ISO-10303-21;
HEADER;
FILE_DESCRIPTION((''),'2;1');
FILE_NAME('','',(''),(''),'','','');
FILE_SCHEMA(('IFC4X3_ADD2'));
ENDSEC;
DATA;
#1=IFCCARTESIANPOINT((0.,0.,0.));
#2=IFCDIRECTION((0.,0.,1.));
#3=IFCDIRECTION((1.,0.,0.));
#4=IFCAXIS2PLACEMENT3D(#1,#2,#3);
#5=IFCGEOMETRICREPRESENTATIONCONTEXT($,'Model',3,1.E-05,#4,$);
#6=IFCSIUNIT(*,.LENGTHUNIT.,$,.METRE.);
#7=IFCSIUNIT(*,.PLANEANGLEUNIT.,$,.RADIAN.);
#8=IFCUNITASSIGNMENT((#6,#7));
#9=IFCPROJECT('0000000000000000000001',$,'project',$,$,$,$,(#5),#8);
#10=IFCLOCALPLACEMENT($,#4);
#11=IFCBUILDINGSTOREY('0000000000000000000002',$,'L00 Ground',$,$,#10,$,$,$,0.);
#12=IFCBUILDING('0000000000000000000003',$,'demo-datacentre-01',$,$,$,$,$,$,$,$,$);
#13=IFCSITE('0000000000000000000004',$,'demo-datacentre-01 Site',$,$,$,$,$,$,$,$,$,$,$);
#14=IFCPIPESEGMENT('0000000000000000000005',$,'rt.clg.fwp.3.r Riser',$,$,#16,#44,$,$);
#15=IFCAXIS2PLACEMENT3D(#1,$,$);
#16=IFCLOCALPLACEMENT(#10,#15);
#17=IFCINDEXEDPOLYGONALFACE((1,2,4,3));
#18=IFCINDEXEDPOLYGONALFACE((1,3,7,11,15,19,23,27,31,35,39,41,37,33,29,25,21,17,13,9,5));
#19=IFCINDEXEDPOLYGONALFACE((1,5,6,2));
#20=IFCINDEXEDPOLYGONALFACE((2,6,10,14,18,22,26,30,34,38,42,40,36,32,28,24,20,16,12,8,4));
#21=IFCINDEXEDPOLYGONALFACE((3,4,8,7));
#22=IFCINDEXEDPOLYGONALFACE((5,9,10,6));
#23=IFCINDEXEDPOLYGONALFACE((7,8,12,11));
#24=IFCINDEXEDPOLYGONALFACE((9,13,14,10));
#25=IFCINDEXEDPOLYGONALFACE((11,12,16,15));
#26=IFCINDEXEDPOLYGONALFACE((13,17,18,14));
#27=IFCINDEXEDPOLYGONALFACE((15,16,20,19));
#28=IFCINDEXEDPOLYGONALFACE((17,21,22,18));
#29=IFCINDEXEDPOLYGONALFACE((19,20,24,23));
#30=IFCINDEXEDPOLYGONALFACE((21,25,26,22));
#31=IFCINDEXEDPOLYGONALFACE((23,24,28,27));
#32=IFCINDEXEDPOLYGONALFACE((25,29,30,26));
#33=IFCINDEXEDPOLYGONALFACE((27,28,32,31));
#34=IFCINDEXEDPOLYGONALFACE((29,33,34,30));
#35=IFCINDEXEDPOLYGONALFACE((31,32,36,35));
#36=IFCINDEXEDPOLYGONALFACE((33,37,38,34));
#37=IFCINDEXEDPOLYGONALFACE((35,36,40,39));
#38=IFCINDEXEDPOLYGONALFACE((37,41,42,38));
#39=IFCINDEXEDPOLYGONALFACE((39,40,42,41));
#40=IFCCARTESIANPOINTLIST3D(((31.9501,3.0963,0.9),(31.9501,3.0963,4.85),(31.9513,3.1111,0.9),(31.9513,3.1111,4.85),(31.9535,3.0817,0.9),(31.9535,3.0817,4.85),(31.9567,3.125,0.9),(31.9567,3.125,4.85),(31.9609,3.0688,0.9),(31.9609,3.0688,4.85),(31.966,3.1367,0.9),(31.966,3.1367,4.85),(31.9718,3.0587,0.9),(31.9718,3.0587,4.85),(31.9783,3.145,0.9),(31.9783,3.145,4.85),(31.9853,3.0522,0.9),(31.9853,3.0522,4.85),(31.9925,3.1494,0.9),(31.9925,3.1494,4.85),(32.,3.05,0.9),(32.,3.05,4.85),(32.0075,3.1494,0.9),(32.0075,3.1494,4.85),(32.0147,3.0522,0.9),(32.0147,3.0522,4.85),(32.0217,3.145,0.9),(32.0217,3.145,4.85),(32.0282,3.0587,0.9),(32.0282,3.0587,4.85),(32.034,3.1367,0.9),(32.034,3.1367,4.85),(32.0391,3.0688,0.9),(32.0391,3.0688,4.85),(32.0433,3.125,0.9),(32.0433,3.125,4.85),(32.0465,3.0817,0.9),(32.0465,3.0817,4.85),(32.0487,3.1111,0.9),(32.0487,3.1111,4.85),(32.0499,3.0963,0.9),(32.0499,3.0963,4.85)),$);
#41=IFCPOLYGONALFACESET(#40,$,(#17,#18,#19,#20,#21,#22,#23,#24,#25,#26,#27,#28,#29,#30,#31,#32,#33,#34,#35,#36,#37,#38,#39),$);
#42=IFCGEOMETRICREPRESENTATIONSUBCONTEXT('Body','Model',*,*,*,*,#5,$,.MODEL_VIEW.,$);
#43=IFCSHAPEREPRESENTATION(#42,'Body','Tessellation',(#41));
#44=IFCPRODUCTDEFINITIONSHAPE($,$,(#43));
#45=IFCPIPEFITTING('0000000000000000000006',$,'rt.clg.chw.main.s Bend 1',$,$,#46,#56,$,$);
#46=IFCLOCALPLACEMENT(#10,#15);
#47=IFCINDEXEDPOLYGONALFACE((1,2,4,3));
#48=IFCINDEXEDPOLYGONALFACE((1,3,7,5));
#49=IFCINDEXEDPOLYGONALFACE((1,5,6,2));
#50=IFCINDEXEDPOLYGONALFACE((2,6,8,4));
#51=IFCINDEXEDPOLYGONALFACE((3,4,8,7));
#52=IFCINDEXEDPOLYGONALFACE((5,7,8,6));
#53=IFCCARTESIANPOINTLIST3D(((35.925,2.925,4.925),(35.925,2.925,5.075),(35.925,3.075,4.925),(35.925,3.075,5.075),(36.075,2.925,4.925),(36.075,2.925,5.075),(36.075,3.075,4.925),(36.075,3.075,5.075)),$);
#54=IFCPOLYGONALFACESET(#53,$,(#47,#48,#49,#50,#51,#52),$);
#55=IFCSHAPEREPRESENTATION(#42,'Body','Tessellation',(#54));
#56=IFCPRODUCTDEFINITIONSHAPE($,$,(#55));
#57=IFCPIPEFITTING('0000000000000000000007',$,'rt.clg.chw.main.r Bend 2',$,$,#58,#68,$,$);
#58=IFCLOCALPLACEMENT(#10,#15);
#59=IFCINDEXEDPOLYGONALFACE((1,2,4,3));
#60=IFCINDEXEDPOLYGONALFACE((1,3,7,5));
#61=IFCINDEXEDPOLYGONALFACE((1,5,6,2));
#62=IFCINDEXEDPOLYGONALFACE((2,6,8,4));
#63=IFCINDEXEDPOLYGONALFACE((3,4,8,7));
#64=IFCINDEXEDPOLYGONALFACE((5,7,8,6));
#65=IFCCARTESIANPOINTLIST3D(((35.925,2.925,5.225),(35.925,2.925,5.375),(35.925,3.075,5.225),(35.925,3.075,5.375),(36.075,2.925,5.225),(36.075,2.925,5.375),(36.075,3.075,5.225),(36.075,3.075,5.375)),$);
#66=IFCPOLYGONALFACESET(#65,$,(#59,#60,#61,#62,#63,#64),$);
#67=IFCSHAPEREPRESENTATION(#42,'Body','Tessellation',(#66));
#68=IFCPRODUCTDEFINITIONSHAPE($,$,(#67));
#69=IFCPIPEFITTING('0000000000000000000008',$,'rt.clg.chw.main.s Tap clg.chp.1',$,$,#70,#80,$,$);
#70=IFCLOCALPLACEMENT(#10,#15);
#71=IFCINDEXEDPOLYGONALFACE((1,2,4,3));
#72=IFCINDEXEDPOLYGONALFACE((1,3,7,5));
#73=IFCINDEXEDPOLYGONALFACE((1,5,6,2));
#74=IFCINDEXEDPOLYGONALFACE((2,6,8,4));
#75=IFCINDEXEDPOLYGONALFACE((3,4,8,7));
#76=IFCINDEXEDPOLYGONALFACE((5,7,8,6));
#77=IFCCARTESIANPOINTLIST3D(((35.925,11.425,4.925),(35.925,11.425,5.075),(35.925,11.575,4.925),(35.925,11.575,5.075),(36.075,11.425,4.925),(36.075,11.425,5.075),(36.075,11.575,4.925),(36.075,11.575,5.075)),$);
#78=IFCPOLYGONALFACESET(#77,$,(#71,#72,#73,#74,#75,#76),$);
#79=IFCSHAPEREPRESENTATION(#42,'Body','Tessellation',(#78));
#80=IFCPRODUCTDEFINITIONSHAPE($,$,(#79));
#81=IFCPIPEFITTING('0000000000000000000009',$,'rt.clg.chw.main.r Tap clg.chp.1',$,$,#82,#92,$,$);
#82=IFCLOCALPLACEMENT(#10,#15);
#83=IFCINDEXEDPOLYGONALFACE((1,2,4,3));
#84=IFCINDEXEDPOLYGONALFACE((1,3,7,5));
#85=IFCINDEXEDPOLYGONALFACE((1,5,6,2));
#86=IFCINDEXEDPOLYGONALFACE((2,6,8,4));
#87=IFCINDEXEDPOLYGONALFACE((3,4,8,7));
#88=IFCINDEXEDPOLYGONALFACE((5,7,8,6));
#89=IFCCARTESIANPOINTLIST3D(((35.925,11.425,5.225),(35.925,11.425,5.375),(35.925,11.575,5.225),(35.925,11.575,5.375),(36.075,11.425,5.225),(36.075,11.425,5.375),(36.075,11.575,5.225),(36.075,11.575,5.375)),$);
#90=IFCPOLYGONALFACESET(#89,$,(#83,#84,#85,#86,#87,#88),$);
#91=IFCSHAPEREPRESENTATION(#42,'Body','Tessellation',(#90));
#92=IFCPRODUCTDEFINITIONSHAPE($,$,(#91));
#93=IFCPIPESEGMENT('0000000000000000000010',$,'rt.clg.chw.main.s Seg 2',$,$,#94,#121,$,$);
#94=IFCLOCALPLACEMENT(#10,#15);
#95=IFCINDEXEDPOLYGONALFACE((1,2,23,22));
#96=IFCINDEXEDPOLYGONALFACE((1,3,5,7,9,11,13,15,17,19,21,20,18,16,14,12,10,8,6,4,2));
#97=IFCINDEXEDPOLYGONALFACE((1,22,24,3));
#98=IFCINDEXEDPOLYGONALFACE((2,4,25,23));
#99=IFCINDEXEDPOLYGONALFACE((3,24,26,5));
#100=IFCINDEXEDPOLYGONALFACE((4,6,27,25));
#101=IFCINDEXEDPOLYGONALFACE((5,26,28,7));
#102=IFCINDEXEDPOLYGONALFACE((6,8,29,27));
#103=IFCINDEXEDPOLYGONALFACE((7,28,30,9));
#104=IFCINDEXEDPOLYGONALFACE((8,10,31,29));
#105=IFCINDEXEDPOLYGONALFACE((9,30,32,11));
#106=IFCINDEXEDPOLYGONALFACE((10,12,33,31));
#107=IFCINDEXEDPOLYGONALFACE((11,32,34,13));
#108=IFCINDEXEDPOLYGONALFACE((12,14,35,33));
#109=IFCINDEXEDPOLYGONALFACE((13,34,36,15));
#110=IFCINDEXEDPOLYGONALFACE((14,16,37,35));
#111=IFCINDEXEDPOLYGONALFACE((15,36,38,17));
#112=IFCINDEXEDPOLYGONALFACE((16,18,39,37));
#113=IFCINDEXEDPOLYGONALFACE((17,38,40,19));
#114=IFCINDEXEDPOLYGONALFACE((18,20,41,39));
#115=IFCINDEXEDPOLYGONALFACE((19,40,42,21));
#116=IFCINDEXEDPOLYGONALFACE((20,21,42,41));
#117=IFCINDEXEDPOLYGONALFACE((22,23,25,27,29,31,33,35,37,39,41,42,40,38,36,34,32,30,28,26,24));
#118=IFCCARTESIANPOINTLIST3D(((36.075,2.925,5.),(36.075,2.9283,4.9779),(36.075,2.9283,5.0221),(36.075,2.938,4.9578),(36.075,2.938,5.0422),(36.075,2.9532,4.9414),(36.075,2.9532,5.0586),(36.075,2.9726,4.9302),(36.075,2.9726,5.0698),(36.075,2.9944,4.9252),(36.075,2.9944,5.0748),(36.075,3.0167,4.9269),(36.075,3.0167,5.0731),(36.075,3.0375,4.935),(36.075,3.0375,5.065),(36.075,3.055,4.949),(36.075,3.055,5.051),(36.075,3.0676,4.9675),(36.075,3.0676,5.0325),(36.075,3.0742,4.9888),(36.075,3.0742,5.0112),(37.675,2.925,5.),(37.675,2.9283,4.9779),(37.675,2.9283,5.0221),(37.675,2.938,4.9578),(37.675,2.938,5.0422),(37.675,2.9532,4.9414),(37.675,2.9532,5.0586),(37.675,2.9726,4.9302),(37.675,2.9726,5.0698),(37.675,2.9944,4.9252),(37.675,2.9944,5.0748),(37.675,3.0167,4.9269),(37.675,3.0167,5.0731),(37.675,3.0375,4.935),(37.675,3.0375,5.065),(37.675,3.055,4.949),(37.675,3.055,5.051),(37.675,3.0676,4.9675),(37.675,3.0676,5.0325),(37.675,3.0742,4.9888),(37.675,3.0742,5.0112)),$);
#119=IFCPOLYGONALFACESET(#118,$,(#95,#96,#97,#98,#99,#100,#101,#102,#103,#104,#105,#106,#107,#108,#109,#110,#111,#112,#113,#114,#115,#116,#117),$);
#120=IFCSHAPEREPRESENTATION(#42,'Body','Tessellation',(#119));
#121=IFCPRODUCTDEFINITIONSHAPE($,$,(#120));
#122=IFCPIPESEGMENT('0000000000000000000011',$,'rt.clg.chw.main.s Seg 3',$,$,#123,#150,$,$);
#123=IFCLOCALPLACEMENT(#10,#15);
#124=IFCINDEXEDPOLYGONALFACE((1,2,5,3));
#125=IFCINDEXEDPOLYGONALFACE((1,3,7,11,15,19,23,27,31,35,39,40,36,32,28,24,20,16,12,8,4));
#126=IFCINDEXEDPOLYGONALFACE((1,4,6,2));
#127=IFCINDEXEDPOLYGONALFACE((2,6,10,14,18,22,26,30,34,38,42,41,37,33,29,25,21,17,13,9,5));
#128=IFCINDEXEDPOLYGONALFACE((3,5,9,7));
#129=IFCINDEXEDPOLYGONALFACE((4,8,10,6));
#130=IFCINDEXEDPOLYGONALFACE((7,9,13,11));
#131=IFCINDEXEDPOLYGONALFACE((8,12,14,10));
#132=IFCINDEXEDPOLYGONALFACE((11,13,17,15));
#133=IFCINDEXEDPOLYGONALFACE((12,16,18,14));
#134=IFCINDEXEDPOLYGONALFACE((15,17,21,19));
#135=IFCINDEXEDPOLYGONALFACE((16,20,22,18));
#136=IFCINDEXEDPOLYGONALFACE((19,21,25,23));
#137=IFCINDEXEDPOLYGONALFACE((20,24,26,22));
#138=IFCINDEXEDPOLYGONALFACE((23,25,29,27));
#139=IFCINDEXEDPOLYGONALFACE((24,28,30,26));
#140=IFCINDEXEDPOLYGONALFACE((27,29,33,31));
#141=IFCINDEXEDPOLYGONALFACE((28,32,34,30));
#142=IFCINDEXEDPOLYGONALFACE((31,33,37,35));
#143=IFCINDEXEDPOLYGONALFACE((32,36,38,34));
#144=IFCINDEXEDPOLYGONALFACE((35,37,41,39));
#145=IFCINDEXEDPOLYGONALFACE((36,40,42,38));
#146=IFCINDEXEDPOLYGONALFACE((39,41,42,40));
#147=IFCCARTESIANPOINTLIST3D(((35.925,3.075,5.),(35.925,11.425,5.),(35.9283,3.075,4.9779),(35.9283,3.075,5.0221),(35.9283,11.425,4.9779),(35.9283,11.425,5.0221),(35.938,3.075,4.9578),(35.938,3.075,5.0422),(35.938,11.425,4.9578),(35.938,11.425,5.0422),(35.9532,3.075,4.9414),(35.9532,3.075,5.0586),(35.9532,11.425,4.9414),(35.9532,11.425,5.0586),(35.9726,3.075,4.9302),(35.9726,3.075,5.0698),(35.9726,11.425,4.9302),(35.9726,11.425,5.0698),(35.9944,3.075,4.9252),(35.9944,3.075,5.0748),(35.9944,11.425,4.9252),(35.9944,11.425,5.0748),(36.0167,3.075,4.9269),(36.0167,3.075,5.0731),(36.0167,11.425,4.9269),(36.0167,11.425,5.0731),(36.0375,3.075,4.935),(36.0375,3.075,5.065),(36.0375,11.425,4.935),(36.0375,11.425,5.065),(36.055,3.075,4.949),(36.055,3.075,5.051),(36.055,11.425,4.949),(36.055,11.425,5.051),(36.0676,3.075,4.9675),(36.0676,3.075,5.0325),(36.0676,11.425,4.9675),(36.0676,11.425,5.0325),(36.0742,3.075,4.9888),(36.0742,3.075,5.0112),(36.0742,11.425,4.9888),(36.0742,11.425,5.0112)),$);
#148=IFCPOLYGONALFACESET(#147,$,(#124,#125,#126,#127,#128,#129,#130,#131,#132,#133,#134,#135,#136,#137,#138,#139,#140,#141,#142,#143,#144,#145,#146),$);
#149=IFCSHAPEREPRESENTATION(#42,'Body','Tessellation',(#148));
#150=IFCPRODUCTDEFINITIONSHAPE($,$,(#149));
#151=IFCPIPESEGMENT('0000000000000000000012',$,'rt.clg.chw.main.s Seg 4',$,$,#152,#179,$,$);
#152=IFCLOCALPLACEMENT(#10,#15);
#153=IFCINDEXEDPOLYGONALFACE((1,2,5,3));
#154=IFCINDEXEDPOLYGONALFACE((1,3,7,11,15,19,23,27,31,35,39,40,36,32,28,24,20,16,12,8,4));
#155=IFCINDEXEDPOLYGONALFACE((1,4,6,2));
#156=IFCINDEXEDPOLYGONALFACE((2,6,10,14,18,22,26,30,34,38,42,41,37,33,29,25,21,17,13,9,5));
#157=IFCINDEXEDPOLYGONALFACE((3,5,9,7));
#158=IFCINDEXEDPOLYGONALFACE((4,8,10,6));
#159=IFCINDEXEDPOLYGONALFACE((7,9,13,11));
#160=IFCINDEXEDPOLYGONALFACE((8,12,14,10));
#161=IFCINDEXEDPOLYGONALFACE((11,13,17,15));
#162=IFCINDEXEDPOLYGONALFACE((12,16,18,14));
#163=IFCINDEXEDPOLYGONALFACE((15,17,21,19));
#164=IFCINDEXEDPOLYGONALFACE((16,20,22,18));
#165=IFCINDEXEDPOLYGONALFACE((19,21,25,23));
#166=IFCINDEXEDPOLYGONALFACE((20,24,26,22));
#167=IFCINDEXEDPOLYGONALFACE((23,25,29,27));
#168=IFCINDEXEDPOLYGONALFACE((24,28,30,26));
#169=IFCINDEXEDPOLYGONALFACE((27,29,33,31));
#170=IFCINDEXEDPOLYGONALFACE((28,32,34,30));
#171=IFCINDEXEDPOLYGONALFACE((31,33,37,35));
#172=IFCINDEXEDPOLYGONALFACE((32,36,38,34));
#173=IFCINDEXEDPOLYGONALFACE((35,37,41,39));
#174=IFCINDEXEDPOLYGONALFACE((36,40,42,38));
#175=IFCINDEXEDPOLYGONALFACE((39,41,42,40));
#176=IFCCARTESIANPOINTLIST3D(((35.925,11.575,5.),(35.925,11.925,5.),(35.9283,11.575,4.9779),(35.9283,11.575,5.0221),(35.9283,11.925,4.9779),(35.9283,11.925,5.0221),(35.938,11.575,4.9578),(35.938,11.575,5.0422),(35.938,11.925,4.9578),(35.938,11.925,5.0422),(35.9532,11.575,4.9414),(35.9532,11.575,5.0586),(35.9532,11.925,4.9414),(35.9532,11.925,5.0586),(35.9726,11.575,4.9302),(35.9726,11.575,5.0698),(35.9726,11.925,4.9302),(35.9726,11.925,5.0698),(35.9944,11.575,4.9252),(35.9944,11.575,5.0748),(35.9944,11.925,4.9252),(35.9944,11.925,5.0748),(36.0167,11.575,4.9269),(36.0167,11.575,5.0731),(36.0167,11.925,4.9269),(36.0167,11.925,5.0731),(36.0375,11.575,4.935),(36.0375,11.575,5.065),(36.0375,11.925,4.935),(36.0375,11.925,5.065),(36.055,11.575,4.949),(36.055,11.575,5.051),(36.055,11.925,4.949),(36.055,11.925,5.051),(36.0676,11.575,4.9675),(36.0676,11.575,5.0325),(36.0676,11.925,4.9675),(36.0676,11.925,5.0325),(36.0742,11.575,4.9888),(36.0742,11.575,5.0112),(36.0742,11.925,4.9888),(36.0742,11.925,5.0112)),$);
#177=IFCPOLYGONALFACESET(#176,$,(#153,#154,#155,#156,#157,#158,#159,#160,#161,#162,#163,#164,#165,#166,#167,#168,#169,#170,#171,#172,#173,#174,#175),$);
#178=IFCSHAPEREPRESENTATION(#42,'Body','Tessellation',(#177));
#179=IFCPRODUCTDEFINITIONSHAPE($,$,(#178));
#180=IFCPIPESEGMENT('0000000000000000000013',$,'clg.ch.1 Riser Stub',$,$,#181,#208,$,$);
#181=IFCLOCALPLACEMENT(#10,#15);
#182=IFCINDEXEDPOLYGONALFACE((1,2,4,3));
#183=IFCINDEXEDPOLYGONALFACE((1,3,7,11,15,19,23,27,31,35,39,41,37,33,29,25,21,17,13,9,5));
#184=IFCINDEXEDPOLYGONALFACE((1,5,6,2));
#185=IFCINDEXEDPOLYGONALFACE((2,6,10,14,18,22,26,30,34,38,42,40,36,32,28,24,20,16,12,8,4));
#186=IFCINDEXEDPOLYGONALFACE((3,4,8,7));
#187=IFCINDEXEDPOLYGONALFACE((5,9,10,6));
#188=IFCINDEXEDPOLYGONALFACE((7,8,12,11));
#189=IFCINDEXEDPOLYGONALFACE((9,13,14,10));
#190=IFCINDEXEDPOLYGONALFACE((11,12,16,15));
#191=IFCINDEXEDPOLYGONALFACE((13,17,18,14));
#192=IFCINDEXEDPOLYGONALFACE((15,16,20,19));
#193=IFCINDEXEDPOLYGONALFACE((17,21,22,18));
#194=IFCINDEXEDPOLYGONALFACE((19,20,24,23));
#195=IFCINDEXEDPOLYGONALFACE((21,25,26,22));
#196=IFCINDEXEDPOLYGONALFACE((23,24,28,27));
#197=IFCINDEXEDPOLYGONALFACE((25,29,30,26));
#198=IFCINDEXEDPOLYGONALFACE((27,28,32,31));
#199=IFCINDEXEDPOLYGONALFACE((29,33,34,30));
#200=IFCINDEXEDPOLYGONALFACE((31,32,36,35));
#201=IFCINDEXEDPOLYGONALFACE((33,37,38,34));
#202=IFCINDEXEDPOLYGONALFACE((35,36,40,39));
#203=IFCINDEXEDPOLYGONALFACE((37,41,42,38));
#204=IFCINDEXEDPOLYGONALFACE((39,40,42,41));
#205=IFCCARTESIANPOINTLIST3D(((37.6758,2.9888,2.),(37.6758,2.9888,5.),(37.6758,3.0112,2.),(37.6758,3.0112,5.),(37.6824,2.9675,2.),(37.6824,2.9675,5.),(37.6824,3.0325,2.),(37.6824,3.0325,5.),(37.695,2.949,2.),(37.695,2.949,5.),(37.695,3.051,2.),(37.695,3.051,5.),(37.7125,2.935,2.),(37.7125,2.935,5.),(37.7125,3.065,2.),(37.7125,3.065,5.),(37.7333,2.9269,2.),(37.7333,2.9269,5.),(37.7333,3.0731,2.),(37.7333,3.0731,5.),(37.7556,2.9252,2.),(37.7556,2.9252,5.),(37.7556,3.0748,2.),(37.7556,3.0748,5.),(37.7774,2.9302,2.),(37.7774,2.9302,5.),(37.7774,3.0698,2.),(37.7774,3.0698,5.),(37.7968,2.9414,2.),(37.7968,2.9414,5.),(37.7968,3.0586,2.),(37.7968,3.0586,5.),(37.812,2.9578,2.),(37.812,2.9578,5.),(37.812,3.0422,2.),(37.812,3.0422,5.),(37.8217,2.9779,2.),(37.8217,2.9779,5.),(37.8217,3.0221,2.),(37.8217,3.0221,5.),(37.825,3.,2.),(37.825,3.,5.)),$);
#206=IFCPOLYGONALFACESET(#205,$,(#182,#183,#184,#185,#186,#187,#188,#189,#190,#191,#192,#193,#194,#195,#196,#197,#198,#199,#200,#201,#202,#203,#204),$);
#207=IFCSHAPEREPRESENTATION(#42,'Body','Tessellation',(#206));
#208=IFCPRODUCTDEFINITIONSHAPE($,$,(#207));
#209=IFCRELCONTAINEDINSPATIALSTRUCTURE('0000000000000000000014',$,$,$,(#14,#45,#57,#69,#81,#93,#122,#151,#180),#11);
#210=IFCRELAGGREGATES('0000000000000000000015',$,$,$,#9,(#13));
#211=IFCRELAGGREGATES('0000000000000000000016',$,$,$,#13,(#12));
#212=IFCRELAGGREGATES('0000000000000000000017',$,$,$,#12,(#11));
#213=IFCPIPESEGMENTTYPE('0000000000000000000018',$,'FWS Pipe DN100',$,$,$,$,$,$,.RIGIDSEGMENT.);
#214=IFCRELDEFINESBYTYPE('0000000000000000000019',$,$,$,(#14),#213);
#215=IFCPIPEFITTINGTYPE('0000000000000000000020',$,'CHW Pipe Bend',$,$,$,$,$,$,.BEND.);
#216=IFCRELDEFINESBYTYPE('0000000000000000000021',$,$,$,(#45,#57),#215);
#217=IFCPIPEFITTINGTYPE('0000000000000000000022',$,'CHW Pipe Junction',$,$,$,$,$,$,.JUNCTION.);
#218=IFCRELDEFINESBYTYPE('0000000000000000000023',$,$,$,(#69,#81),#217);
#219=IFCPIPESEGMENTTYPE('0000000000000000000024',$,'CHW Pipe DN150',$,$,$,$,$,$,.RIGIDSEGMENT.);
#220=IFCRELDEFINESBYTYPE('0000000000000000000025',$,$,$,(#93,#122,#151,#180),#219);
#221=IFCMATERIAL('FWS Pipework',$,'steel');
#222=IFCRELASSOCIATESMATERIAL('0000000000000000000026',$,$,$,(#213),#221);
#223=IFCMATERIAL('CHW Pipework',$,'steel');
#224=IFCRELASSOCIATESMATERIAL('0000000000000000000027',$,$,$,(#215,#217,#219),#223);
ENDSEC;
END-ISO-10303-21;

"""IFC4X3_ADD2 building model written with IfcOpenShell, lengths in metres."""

from ifc_helpers import new_model, si_unit, frame, origin_with_axes, place, context, subcontext, project, spatial, rectangle, circle, extrude, material, type_object, element, save


model = new_model("IFC4X3_ADD2")

# Units and contexts
model_context = context("Model", 3, precision=1e-05, world=origin_with_axes())
body_context = subcontext(model_context, "Body", "Model", "MODEL_VIEW")
ifc_project = project(units=[si_unit("LENGTHUNIT", "METRE"), si_unit("PLANEANGLEUNIT", "RADIAN")], contexts=[model_context])

# Site, building, storey
site = spatial("IfcSite", under=ifc_project, Name="demo-datacentre-01 Site")
building = spatial("IfcBuilding", under=site, Name="demo-datacentre-01")
storey_placement = place(None, origin_with_axes())
storey = spatial("IfcBuildingStorey", under=building, at=storey_placement, Name="L00 Ground", Elevation=0.0)

# Shared definitions
ifc_material_1 = material(Name="FWS Pipework", Category="steel")

# Pipe segment
pipe_segment_type_1 = type_object("IfcPipeSegmentType", Name="FWS Pipe DN100", PredefinedType="RIGIDSEGMENT", material=ifc_material_1)
pipe_segment_1_placement = place(storey_placement, frame((32.0, 3.1, 0.9), z_axis=(0.0, 0.0, 1.0), x_axis=(0.0, -1.0, 0.0)))
element("IfcPipeSegment", 1, at=pipe_segment_1_placement, inside=storey, type_object=pipe_segment_type_1, Name="rt.clg.fwp.3.r Riser", context=body_context, shape_type="SweptSolid", body=[
    extrude(circle(Radius=0.05), origin_with_axes(), (0.0, 0.0, 1.0), 3.95),
])

# Pipe fittings
ifc_material_2 = material(Name="CHW Pipework", Category="steel")
pipe_fitting_type_1 = type_object("IfcPipeFittingType", Name="CHW Pipe Bend", PredefinedType="BEND", material=ifc_material_2)
for number, where, z_axis, x_axis, name in (
    (2, (36.0, 3.0, 4.925), (0.0, 0.0, 1.0), (1.0, 0.0, 0.0), "rt.clg.chw.main.s Bend 1"),
    (3, (36.0, 3.0, 5.225), (0.0, 0.0, 1.0), (1.0, 0.0, 0.0), "rt.clg.chw.main.r Bend 2"),
):
    element("IfcPipeFitting", number, at=place(storey_placement, frame(where, z_axis=z_axis, x_axis=x_axis)), inside=storey, type_object=pipe_fitting_type_1, Name=name, context=body_context, shape_type="SweptSolid", body=[
        extrude(rectangle(XDim=0.15, YDim=0.15), origin_with_axes(), (0.0, 0.0, 1.0), 0.15),
    ])
pipe_fitting_type_2 = type_object("IfcPipeFittingType", Name="CHW Pipe Junction", PredefinedType="JUNCTION", material=ifc_material_2)
for number, where, z_axis, x_axis, name in (
    (4, (36.0, 11.5, 4.925), (0.0, 0.0, 1.0), (1.0, 0.0, 0.0), "rt.clg.chw.main.s Tap clg.chp.1"),
    (5, (36.0, 11.5, 5.225), (0.0, 0.0, 1.0), (1.0, 0.0, 0.0), "rt.clg.chw.main.r Tap clg.chp.1"),
):
    element("IfcPipeFitting", number, at=place(storey_placement, frame(where, z_axis=z_axis, x_axis=x_axis)), inside=storey, type_object=pipe_fitting_type_2, Name=name, context=body_context, shape_type="SweptSolid", body=[
        extrude(rectangle(XDim=0.15, YDim=0.15), origin_with_axes(), (0.0, 0.0, 1.0), 0.15),
    ])

# Pipe segments
pipe_segment_type_2 = type_object("IfcPipeSegmentType", Name="CHW Pipe DN150", PredefinedType="RIGIDSEGMENT", material=ifc_material_2)
pipe_segment_2_placement = place(storey_placement, frame((37.675, 3.0, 5.0), z_axis=(-1.0, 0.0, 0.0), x_axis=(0.0, -1.0, 0.0)))
element("IfcPipeSegment", 6, at=pipe_segment_2_placement, inside=storey, type_object=pipe_segment_type_2, Name="rt.clg.chw.main.s Seg 2", context=body_context, shape_type="SweptSolid", body=[
    extrude(circle(Radius=0.075), origin_with_axes(), (0.0, 0.0, 1.0), 1.6),
])
pipe_segment_3_placement = place(storey_placement, frame((36.0, 3.075, 5.0), z_axis=(0.0, 1.0, 0.0), x_axis=(-1.0, 0.0, 0.0)))
element("IfcPipeSegment", 7, at=pipe_segment_3_placement, inside=storey, type_object=pipe_segment_type_2, Name="rt.clg.chw.main.s Seg 3", context=body_context, shape_type="SweptSolid", body=[
    extrude(circle(Radius=0.075), origin_with_axes(), (0.0, 0.0, 1.0), 8.35),
])
pipe_segment_4_placement = place(storey_placement, frame((36.0, 11.575, 5.0), z_axis=(0.0, 1.0, 0.0), x_axis=(-1.0, 0.0, 0.0)))
element("IfcPipeSegment", 8, at=pipe_segment_4_placement, inside=storey, type_object=pipe_segment_type_2, Name="rt.clg.chw.main.s Seg 4", context=body_context, shape_type="SweptSolid", body=[
    extrude(circle(Radius=0.075), origin_with_axes(), (0.0, 0.0, 1.0), 0.35),
])
pipe_segment_5_placement = place(storey_placement, frame((37.75, 3.0, 5.0), z_axis=(0.0, 0.0, -1.0), x_axis=(1.0, 0.0, 0.0)))
element("IfcPipeSegment", 9, at=pipe_segment_5_placement, inside=storey, type_object=pipe_segment_type_2, Name="clg.ch.1 Riser Stub", context=body_context, shape_type="SweptSolid", body=[
    extrude(circle(Radius=0.075), origin_with_axes(), (0.0, 0.0, 1.0), 3.0),
])

save(model, "model.ifc")
